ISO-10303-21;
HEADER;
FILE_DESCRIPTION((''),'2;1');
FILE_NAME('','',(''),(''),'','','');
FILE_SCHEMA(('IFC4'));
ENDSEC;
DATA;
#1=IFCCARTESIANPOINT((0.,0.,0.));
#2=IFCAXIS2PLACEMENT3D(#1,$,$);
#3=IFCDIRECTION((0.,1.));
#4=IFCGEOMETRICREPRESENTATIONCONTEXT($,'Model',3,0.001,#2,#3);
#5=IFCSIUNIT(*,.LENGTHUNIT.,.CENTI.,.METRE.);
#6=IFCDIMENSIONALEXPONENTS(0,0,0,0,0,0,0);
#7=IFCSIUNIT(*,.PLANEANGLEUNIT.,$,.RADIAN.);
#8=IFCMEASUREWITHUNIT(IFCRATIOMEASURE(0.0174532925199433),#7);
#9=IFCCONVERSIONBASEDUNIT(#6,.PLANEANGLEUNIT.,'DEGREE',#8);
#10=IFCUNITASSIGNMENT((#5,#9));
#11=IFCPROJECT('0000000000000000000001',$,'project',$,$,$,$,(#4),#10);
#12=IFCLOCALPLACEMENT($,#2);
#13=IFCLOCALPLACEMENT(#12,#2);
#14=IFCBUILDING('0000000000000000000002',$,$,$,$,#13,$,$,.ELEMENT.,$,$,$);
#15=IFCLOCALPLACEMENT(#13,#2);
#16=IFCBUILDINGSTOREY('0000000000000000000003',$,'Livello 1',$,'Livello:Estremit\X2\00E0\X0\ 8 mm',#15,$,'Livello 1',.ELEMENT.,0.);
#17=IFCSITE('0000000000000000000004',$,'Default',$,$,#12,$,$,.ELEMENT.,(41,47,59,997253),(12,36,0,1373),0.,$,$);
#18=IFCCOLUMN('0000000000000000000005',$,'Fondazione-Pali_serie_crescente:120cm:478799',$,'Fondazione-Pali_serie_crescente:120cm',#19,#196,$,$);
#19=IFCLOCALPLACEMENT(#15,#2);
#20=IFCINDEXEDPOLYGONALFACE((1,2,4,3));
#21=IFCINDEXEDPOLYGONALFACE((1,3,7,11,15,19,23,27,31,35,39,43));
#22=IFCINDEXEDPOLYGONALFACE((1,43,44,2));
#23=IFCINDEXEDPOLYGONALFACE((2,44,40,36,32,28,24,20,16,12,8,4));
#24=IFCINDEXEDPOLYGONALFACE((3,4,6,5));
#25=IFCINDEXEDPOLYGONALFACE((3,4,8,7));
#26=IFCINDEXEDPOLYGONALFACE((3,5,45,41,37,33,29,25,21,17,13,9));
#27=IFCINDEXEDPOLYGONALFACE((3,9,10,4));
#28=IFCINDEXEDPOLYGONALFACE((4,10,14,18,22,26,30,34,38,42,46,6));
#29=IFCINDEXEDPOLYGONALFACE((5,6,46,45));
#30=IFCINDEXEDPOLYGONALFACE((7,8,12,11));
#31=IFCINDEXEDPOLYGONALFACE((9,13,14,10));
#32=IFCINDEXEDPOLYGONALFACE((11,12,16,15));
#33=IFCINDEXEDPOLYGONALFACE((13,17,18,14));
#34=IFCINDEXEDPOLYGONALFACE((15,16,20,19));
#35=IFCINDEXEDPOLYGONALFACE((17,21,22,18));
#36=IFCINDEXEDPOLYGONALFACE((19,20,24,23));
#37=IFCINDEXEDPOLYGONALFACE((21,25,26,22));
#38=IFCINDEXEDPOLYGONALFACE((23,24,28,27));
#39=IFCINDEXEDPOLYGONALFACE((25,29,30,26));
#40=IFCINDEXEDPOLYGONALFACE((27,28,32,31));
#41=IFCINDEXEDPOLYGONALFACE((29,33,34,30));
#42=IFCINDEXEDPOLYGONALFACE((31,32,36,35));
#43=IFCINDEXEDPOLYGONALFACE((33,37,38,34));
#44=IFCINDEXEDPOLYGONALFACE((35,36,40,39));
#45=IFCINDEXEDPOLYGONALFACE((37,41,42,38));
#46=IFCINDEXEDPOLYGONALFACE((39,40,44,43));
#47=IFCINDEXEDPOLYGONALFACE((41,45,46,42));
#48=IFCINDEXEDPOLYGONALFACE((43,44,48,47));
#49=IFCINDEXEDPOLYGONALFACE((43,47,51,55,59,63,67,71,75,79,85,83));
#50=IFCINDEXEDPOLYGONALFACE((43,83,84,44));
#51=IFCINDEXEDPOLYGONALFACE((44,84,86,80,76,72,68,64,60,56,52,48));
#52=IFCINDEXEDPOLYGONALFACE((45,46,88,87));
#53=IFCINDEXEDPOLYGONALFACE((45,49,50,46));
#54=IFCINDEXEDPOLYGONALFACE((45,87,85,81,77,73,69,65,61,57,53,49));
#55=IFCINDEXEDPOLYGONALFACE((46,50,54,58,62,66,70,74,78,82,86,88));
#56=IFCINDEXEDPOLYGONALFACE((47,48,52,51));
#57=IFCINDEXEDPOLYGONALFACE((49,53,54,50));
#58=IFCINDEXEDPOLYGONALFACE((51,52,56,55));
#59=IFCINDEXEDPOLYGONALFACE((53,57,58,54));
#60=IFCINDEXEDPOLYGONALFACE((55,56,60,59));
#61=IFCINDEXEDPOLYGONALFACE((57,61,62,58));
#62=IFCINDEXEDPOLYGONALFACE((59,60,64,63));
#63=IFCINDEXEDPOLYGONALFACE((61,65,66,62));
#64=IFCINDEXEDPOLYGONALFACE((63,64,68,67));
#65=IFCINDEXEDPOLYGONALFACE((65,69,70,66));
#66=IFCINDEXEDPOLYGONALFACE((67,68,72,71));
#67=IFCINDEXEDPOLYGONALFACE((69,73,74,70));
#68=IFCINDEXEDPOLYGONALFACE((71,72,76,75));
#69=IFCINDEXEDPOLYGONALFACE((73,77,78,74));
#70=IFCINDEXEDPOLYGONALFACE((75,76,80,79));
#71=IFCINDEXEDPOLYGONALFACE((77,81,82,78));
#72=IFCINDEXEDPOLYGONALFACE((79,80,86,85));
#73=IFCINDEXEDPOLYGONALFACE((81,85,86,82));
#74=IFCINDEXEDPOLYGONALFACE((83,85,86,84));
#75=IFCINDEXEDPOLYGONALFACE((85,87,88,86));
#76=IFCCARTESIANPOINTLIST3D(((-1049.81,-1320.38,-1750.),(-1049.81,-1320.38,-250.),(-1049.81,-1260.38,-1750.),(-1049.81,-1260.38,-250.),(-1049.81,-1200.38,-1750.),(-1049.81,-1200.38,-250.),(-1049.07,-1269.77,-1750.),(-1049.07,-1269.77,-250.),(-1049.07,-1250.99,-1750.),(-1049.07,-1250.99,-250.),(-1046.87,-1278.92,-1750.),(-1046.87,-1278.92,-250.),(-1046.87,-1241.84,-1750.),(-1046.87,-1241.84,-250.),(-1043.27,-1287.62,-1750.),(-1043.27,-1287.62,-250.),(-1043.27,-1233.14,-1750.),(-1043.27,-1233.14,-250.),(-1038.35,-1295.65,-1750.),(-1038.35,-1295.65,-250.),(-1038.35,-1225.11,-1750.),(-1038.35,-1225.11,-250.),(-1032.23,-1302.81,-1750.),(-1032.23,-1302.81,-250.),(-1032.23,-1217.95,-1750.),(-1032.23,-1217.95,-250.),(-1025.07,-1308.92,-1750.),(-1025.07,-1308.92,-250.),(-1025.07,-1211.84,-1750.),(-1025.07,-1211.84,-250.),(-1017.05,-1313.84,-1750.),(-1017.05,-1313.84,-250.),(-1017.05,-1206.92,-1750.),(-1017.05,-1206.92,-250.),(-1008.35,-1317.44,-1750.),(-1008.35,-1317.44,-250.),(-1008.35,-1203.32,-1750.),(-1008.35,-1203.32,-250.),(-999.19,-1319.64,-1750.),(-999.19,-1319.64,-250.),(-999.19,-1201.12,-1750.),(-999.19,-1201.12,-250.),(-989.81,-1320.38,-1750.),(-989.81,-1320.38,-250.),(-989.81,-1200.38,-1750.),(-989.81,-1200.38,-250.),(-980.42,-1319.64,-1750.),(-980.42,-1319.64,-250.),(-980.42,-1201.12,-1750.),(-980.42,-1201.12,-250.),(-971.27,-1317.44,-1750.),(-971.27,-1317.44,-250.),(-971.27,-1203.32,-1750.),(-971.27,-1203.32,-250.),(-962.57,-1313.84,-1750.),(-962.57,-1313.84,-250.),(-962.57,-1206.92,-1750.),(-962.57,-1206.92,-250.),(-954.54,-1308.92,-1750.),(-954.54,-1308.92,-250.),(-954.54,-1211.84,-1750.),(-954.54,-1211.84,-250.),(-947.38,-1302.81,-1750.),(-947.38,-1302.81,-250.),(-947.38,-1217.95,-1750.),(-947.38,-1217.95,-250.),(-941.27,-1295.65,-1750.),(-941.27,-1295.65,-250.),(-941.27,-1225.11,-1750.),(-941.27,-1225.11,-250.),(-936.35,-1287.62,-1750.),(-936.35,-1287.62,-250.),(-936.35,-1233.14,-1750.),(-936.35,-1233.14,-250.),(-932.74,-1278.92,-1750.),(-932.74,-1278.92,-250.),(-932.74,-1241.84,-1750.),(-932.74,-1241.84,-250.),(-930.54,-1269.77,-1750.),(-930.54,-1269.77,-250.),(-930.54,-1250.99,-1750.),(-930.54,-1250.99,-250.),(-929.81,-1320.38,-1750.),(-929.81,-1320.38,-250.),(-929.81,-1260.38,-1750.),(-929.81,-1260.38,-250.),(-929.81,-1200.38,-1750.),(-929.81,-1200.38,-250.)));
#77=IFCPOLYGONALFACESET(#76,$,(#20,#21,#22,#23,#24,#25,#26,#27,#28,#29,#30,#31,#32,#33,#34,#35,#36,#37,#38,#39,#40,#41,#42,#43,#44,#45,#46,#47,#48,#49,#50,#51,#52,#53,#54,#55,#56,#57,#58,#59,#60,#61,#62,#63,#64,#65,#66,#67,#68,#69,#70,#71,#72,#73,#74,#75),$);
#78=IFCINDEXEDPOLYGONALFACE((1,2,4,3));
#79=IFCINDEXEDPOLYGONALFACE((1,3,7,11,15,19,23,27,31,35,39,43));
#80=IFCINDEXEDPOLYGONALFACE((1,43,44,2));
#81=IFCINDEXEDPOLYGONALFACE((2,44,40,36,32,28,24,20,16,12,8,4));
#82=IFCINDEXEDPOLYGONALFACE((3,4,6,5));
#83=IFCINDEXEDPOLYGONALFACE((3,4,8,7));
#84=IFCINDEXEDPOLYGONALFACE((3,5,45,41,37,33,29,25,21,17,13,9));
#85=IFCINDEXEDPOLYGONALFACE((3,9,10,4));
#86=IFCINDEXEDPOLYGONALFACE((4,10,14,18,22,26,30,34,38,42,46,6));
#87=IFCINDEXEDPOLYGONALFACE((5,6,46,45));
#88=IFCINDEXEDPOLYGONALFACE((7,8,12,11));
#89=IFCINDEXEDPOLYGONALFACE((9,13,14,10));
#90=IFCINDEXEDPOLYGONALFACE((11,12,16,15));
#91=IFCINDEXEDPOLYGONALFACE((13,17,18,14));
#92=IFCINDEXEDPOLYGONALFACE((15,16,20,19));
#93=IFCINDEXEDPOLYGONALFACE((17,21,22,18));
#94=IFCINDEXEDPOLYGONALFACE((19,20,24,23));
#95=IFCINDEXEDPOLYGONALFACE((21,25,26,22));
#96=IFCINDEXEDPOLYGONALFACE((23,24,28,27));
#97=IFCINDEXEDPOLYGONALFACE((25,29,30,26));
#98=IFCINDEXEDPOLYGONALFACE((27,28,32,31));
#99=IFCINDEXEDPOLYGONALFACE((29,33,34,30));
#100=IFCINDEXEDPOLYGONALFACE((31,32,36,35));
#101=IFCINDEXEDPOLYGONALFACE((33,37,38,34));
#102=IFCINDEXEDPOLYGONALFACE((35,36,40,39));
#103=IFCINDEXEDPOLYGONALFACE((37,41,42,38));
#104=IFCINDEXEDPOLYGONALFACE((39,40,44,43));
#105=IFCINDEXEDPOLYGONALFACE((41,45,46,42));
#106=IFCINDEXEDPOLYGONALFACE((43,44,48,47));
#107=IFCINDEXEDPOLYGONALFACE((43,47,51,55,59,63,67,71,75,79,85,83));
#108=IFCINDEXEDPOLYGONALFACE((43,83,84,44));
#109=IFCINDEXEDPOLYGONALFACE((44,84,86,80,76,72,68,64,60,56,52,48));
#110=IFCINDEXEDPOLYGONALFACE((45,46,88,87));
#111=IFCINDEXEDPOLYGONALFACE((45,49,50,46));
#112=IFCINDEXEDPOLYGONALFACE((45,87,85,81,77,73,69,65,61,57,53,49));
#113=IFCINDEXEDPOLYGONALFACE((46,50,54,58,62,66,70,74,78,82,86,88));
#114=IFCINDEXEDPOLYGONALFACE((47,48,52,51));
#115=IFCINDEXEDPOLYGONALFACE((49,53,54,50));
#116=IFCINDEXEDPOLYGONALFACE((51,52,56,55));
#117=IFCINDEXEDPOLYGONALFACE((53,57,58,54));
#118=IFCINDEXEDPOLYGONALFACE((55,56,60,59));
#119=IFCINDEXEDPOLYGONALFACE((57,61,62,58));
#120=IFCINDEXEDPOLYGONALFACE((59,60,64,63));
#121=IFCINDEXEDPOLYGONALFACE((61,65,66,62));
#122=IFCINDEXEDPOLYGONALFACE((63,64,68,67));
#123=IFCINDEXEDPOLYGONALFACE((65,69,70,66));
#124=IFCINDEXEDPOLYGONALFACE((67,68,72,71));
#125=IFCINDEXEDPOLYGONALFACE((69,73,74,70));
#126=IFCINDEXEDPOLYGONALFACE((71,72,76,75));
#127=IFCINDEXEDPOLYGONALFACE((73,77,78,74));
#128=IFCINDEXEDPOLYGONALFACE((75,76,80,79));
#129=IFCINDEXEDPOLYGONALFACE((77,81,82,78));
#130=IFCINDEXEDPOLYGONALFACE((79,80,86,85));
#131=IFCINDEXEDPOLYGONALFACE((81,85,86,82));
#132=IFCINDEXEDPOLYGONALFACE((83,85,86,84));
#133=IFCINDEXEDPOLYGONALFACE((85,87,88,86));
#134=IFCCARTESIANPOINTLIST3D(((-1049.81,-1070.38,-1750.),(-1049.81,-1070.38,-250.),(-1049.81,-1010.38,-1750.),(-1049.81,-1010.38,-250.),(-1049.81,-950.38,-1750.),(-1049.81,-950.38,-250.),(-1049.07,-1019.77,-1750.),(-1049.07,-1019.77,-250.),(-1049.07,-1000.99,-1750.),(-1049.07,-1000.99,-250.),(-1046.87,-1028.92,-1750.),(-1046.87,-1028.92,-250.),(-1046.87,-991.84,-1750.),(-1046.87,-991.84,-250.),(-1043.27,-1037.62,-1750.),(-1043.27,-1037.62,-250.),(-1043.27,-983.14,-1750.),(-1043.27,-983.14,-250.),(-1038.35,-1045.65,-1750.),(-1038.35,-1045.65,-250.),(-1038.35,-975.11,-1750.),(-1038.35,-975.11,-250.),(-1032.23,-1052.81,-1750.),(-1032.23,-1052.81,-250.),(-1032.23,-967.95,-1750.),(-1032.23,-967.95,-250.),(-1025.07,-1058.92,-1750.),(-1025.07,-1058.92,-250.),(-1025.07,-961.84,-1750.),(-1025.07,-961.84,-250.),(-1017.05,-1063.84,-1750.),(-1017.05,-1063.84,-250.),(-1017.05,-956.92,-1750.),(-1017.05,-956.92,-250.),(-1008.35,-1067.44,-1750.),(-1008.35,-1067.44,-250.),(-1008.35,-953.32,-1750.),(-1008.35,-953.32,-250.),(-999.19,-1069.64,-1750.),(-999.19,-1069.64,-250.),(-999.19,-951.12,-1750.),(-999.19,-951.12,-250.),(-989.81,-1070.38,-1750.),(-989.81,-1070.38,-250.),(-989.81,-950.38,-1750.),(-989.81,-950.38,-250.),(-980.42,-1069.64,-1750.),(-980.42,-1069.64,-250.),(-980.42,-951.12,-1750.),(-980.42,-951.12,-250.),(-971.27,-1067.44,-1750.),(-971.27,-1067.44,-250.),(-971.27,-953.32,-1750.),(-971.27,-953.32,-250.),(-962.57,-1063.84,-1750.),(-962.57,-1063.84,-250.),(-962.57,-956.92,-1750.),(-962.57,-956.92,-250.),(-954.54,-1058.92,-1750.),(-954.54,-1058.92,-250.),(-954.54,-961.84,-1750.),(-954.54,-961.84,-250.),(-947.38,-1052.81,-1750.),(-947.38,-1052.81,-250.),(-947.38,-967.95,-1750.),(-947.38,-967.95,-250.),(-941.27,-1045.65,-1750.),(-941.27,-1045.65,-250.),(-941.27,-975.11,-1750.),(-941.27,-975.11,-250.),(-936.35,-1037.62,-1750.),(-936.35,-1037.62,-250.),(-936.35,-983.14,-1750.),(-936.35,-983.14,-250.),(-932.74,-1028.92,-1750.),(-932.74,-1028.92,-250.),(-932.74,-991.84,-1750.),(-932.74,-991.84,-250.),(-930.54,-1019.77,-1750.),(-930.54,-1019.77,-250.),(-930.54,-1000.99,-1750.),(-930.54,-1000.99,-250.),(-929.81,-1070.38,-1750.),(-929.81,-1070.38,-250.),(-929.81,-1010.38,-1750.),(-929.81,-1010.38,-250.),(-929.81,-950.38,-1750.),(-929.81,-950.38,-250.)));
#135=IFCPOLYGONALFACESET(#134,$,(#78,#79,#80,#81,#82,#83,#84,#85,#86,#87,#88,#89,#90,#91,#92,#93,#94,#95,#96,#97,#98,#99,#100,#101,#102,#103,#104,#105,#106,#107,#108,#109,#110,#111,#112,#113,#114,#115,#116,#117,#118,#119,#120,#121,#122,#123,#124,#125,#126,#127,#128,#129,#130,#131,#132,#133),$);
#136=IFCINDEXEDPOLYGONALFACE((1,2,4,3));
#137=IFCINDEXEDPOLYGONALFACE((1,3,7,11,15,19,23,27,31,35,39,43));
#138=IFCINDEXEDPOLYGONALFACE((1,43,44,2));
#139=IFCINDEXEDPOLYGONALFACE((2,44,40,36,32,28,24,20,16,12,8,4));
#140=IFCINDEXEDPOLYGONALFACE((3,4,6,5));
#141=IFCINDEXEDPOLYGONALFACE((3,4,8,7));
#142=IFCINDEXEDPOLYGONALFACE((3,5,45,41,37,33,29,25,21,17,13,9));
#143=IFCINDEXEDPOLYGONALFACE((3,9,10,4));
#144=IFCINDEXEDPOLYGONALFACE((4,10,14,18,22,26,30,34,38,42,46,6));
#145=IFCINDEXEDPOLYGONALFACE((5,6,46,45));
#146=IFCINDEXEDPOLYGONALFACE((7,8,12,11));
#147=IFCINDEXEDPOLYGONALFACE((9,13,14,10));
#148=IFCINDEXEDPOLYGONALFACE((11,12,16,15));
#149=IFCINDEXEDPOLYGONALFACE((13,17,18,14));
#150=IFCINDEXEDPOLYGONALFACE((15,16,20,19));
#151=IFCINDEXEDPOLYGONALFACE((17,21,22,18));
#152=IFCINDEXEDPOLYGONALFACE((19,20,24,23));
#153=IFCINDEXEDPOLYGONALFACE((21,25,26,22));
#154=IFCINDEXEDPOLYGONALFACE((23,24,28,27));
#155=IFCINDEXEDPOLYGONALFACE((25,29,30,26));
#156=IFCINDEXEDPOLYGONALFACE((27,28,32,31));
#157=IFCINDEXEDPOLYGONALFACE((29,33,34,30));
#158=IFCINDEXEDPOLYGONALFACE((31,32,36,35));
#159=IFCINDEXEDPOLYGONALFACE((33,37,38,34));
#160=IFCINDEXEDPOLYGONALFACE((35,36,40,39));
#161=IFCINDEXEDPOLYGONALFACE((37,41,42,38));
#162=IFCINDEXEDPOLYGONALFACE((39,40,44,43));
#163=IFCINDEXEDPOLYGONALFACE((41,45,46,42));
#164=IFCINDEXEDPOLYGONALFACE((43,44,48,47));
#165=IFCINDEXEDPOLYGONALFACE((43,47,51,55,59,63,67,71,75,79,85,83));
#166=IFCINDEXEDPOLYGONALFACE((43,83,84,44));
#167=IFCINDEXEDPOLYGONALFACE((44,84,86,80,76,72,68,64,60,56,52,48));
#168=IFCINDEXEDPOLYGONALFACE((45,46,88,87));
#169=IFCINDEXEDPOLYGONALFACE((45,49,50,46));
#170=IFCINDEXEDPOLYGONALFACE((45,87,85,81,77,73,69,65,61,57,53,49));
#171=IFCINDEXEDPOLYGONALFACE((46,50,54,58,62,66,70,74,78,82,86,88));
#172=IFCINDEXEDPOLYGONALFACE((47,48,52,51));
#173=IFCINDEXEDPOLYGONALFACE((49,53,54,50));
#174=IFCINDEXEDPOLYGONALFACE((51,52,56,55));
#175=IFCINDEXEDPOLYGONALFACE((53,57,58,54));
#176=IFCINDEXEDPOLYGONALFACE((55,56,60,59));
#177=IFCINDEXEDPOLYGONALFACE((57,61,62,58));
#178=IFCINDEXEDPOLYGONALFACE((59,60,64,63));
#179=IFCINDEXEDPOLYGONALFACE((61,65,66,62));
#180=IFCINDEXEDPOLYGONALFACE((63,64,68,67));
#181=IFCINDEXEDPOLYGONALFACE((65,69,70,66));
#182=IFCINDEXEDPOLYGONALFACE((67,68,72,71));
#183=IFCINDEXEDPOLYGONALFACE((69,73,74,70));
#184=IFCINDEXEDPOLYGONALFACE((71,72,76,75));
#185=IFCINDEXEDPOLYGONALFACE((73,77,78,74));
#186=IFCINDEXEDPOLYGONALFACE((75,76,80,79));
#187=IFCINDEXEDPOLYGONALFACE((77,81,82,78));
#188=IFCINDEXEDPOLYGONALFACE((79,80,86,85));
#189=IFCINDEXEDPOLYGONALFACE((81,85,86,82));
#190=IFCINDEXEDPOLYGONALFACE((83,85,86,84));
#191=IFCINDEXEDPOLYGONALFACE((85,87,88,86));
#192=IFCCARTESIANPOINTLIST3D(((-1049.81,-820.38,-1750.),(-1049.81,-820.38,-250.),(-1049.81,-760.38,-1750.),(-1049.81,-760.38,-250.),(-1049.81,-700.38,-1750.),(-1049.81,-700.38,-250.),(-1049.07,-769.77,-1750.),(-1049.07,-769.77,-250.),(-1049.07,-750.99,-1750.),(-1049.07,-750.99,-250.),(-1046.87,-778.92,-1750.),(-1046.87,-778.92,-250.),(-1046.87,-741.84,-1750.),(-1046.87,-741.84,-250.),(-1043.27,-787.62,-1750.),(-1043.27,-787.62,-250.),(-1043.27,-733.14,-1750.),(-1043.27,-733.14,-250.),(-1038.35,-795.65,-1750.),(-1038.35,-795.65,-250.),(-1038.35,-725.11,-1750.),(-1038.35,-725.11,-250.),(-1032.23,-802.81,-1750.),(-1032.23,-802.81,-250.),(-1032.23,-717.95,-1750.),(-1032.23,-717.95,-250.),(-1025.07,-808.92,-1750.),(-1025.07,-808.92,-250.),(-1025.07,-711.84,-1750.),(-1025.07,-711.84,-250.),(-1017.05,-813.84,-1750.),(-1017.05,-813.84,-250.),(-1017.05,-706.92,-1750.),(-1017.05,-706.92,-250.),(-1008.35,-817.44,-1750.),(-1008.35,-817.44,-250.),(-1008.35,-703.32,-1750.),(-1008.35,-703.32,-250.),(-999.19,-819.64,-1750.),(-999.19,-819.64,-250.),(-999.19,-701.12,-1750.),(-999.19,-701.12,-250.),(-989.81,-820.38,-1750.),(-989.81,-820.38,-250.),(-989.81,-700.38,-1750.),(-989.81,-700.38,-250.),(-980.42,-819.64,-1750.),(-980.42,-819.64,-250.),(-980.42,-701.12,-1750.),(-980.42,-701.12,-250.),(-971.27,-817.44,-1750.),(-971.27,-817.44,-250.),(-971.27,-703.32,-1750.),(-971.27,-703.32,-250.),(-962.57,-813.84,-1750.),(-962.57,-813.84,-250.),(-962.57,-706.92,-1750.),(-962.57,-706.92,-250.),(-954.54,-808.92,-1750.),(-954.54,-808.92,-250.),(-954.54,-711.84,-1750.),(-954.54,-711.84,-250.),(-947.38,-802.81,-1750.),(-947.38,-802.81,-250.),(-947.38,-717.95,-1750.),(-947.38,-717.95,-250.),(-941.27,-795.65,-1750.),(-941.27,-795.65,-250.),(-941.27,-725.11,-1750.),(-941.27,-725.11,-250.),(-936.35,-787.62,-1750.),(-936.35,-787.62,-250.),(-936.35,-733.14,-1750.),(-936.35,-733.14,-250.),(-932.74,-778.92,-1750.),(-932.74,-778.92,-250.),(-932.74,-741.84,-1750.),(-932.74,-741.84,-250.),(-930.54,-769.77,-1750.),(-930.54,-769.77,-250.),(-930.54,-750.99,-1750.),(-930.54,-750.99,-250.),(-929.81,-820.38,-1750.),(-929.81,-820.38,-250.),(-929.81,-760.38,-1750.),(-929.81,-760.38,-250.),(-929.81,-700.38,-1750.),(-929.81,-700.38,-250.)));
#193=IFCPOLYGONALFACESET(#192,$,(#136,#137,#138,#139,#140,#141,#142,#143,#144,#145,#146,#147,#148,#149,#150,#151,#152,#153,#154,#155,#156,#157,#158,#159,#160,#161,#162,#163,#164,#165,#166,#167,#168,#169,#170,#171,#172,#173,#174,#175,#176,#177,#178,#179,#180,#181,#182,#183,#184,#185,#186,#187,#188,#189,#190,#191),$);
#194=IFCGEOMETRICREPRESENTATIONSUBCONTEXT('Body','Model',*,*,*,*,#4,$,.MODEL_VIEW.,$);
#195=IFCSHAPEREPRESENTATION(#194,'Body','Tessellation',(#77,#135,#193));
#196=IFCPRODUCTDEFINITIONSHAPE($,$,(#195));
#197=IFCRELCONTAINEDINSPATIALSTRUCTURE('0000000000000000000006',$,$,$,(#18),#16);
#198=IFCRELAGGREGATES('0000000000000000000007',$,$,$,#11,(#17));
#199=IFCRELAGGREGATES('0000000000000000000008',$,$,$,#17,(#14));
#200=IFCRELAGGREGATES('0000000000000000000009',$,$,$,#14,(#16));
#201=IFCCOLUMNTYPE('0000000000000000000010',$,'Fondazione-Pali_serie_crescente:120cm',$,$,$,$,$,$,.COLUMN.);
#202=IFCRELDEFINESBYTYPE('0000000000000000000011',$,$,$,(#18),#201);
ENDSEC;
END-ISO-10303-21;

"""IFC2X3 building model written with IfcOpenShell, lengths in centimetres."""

from ifc_helpers import new_model, entity, si_unit, converted_unit, direction, frame, frame_2d, origin, origin_2d_with_axis, place, context, subcontext, project, spatial, rectangle, circle, extrude, boolean, source, transform, mapped, type_object, type_shapes, element, save


model = new_model("IFC2X3")

# Units and contexts
model_context = context("Model", 3, precision=0.001, world=origin(), true_north=direction((0.0, 1.0)))
body_context = subcontext(model_context, "Body", "Model", "MODEL_VIEW")
ifc_project = project(units=[si_unit("LENGTHUNIT", "METRE", prefix="CENTI"), converted_unit("PLANEANGLEUNIT", "DEGREE", entity("IfcRatioMeasure", 0.0174532925199433), si_unit("PLANEANGLEUNIT", "RADIAN"), dimensions=[0, 0, 0, 0, 0, 0, 0])], contexts=[model_context])

# Site, building, storey
site_placement = place(None, origin())
site = spatial("IfcSite", under=ifc_project, at=site_placement, Name="Default", CompositionType="ELEMENT", RefLatitude=(41, 47, 59, 997253), RefLongitude=(12, 36, 0, 1373), RefElevation=0.0)
building_placement = place(site_placement, origin())
building = spatial("IfcBuilding", under=site, at=building_placement, CompositionType="ELEMENT")
storey_placement = place(building_placement, origin())
storey = spatial("IfcBuildingStorey", under=building, at=storey_placement, Name="Livello 1", ObjectType="Livello:Estremità 8 mm", LongName="Livello 1", CompositionType="ELEMENT", Elevation=0.0)

# Column
column_type_1 = type_object("IfcColumnType", Name="Fondazione-Pali_serie_crescente:120cm", PredefinedType="COLUMN")
shared_shape_1 = source(origin(), body_context, "Body", "SweptSolid", [
    boolean("DIFFERENCE", extrude(rectangle(XDim=1500.0, YDim=120.0, at=origin_2d_with_axis()), frame((710.0, 0.0, -750.0), z_axis=(1.0, 0.0, 0.0), x_axis=(0.0, 0.0, -1.0)), (0.0, 0.0, 1.0), 120.0), extrude(circle(Radius=60.0, at=frame_2d((0.0, 0.0), x_axis=(1.0, 0.0))), frame((770.0, 0.0, -1500.0), z_axis=(0.0, 0.0, -1.0), x_axis=(1.0, 0.0, 0.0)), (0.0, 0.0, -1.0), 1500.0)),
    boolean("DIFFERENCE", extrude(rectangle(XDim=1500.0, YDim=120.0, at=origin_2d_with_axis()), frame((460.0, 0.0, -750.0), z_axis=(1.0, 0.0, 0.0), x_axis=(0.0, 0.0, -1.0)), (0.0, 0.0, 1.0), 120.0), extrude(circle(Radius=60.0, at=frame_2d((0.0, 0.0), x_axis=(1.0, 0.0))), frame((520.0, 0.0, -1500.0), z_axis=(0.0, 0.0, -1.0), x_axis=(1.0, 0.0, 0.0)), (0.0, 0.0, -1.0), 1500.0)),
    boolean("DIFFERENCE", extrude(rectangle(XDim=1500.0, YDim=120.0, at=origin_2d_with_axis()), frame((210.0, 0.0, -750.0), z_axis=(1.0, 0.0, 0.0), x_axis=(0.0, 0.0, -1.0)), (0.0, 0.0, 1.0), 120.0), extrude(circle(Radius=60.0, at=frame_2d((0.0, 0.0), x_axis=(1.0, 0.0))), frame((270.0, 0.0, -1500.0), z_axis=(0.0, 0.0, -1.0), x_axis=(1.0, 0.0, 0.0)), (0.0, 0.0, -1.0), 1500.0)),
])
type_shapes(column_type_1, [shared_shape_1])
for number, where, z_axis, x_axis, name in (
    (1, (-989.81, -490.38, -250.0), (0.0, 0.0, 1.0), (0.0, -1.0, 0.0), "Fondazione-Pali_serie_crescente:120cm:478799"),
):
    element("IfcColumn", number, at=place(storey_placement, frame(where, z_axis=z_axis, x_axis=x_axis)), inside=storey, type_object=column_type_1, Name=name, ObjectType="Fondazione-Pali_serie_crescente:120cm", context=body_context, shape_type="MappedRepresentation", body=[
        mapped(shared_shape_1, transform((0.0, 0.0, 0.0), scale=1.0)),
    ])

save(model, "model.ifc")
